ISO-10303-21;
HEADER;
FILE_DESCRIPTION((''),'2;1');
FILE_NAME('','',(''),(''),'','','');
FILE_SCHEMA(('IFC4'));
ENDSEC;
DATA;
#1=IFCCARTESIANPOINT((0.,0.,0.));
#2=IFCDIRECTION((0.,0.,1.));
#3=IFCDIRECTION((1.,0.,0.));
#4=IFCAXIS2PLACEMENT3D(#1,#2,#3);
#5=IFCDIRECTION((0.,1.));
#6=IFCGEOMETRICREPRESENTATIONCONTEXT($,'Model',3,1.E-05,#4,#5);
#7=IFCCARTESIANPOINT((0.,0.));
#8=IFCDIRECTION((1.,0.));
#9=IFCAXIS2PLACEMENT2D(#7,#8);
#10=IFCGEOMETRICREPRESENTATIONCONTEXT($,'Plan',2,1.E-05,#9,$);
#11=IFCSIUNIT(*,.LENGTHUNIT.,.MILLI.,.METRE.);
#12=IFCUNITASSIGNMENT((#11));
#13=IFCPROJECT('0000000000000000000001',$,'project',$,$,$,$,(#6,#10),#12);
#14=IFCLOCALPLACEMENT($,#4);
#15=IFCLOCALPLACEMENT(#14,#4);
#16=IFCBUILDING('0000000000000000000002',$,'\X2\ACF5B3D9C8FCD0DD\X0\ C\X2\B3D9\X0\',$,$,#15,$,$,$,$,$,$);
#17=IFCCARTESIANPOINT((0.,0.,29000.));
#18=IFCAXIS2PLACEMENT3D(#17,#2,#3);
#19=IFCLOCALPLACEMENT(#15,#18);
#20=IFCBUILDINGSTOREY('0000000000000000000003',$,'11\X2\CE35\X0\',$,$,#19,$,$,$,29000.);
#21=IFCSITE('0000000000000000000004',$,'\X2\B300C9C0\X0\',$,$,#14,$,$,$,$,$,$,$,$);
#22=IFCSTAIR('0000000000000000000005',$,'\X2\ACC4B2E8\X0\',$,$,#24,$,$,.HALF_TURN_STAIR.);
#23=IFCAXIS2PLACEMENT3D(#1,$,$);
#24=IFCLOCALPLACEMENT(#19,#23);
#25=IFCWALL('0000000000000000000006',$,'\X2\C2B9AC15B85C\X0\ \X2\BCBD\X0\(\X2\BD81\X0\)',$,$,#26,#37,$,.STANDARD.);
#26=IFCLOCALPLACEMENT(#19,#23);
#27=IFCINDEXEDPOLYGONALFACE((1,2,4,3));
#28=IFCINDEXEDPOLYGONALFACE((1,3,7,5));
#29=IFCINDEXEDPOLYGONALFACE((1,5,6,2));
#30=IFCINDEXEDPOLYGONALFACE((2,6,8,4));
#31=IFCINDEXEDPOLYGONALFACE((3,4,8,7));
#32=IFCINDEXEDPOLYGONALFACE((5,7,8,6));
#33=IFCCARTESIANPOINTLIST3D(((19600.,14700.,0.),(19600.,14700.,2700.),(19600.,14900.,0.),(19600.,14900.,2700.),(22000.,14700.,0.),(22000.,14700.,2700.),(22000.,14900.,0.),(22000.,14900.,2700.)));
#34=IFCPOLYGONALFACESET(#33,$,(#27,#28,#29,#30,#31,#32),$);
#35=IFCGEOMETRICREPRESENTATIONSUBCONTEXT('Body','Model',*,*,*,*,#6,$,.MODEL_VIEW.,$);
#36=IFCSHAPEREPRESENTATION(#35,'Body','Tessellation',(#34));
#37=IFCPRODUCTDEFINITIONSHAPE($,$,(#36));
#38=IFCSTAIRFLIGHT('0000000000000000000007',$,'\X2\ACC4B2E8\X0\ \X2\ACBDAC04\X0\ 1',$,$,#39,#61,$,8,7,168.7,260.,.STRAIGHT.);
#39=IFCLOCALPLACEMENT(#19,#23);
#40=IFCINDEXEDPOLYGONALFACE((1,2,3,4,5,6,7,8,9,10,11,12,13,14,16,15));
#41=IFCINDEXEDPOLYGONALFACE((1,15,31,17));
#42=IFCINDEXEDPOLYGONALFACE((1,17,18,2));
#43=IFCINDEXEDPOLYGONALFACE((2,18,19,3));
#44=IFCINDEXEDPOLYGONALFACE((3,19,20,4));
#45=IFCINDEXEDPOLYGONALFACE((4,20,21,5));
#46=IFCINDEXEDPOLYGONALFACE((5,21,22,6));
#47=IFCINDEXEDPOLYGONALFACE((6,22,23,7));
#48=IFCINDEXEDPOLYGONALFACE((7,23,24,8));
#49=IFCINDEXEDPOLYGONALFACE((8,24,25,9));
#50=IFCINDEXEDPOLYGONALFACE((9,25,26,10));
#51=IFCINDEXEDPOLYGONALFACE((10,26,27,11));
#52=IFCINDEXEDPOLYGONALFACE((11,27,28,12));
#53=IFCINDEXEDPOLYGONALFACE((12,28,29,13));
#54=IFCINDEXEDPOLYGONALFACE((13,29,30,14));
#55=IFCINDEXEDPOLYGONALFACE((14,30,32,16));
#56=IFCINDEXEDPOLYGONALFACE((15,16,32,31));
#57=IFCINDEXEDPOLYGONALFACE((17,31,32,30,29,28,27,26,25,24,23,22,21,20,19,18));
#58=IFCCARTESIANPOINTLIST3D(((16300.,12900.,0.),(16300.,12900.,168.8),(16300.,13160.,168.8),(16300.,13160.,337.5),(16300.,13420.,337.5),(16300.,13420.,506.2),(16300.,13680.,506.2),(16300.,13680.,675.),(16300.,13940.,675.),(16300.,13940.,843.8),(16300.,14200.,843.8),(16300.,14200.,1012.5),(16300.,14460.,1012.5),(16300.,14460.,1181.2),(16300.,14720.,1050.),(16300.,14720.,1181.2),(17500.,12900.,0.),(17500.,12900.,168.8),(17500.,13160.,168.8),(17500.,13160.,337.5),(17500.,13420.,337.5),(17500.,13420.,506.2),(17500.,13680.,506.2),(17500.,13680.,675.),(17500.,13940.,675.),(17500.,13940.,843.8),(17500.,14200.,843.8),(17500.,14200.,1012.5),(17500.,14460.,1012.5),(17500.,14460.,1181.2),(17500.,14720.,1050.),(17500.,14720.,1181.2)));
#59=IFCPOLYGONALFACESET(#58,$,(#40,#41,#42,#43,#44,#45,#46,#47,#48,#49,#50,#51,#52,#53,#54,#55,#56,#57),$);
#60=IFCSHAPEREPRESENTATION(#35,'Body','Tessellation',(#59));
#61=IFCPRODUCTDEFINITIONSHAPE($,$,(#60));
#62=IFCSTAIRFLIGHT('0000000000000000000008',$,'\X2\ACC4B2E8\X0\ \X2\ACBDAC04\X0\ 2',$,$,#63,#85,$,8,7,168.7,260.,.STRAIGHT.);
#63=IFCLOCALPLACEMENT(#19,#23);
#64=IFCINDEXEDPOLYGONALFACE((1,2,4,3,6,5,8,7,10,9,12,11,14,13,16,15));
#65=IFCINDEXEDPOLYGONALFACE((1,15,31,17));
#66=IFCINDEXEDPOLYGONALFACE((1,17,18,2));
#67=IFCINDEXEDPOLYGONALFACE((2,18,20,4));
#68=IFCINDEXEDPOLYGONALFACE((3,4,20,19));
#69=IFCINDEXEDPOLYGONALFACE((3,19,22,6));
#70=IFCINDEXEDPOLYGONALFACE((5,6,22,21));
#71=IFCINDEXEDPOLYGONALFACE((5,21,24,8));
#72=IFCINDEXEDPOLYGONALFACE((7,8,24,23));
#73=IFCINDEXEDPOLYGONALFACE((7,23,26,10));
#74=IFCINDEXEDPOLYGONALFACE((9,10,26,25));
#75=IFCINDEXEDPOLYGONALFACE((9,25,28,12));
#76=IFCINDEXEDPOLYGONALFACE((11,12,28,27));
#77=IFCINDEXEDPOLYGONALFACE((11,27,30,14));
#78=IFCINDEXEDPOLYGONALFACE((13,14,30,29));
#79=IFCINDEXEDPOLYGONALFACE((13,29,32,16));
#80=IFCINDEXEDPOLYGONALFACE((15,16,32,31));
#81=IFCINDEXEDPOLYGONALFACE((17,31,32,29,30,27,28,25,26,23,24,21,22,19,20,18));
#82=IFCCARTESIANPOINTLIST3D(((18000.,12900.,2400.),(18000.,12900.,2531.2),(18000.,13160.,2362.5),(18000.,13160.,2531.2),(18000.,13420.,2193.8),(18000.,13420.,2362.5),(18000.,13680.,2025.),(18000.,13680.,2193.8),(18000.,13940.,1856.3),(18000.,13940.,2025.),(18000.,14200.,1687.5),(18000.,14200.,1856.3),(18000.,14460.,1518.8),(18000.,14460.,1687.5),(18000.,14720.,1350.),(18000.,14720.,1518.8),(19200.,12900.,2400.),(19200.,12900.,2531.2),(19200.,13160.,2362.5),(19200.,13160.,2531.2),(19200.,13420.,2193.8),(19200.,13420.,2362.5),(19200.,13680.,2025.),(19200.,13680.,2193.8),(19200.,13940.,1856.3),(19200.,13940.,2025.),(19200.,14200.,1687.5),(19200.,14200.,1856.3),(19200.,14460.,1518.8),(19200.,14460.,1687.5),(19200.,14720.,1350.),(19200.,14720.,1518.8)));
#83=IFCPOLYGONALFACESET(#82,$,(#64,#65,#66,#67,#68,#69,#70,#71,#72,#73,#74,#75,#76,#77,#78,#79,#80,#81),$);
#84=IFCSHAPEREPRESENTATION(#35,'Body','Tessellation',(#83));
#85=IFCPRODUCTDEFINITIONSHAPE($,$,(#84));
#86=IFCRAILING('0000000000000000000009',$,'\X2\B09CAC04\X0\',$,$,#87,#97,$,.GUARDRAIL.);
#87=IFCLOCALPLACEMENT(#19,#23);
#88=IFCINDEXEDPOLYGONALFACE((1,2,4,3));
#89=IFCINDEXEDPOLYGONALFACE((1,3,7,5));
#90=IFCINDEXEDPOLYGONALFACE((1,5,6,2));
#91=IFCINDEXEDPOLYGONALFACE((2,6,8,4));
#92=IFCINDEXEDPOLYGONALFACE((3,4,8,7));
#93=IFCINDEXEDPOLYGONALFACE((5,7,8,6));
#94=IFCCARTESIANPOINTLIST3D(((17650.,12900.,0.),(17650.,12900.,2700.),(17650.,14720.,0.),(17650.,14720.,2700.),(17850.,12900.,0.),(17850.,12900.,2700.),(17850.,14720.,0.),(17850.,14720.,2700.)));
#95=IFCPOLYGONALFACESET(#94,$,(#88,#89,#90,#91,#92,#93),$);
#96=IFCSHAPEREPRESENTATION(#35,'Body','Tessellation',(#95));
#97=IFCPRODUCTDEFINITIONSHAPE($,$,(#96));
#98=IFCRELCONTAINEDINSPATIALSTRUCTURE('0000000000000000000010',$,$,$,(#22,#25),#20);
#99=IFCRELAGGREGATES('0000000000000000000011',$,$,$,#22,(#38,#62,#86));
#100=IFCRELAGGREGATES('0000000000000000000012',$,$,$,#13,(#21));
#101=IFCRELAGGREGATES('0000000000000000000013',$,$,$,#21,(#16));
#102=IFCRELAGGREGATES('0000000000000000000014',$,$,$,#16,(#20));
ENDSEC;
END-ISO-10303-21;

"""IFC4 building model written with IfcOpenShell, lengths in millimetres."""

from ifc_helpers import new_model, si_unit, direction, frame, origin_with_axes, origin_2d_with_axis, place, context, subcontext, project, spatial, polyline, outline, extrude, element, aggregate, save


model = new_model("IFC4")

# Units and contexts
model_context = context("Model", 3, precision=1e-05, world=origin_with_axes(), true_north=direction((0.0, 1.0)))
plan_context = context("Plan", 2, precision=1e-05, world=origin_2d_with_axis())
body_context = subcontext(model_context, "Body", "Model", "MODEL_VIEW")
ifc_project = project(units=[si_unit("LENGTHUNIT", "METRE", prefix="MILLI")], contexts=[model_context, plan_context])

# Site, building, storey
site_placement = place(None, origin_with_axes())
site = spatial("IfcSite", under=ifc_project, at=site_placement, Name="대지")
building_placement = place(site_placement, origin_with_axes())
building = spatial("IfcBuilding", under=site, at=building_placement, Name="공동주택 C동")
storey_placement = place(building_placement, frame((0.0, 0.0, 29000.0), z_axis=(0.0, 0.0, 1.0), x_axis=(1.0, 0.0, 0.0)))
storey = spatial("IfcBuildingStorey", under=building, at=storey_placement, Name="11층", Elevation=29000.0)

# Stair
stair_placement = place(storey_placement, origin_with_axes())
stair = element("IfcStair", 1, at=stair_placement, inside=storey, Name="계단", PredefinedType="HALF_TURN_STAIR")

# Wall
wall_1_placement = place(storey_placement, origin_with_axes())
element("IfcWall", 2, at=wall_1_placement, inside=storey, Name="승강로 벽(북)", PredefinedType="STANDARD", context=body_context, shape_type="SweptSolid", body=[
    extrude(outline(polyline([(19600.0, 14900.0), (22000.0, 14900.0), (22000.0, 14700.0), (19600.0, 14700.0), (19600.0, 14900.0)])), origin_with_axes(), (0.0, 0.0, 1.0), 2700.0),
])

# Stair flights
stair_flight_1_placement = place(stair_placement, origin_with_axes())
stair_flight_1 = element("IfcStairFlight", 3, at=stair_flight_1_placement, Name="계단 경간 1", NumberOfRisers=8, NumberOfTreads=7, PredefinedType="STRAIGHT", RiserHeight=168.7, TreadLength=260.0, context=body_context, shape_type="SweptSolid", body=[
    extrude(outline(polyline([(0.0, 0.0), (0.0, 168.7), (260.0, 168.7), (260.0, 337.5), (520.0, 337.5), (520.0, 506.2), (780.0, 506.2), (780.0, 675.0), (1040.0, 675.0), (1040.0, 843.7), (1300.0, 843.7), (1300.0, 1012.5), (1560.0, 1012.5), (1560.0, 1181.2), (1820.0, 1181.2), (1820.0, 1350.0), (1820.0, 1050.0), (0.0, 0.0)])), frame((16300.0, 12900.0, 0.0), z_axis=(1.0, 0.0, 0.0), x_axis=(0.0, 1.0, 0.0)), (0.0, 0.0, 1.0), 1200.0),
])
stair_flight_2_placement = place(stair_placement, origin_with_axes())
stair_flight_2 = element("IfcStairFlight", 4, at=stair_flight_2_placement, Name="계단 경간 2", NumberOfRisers=8, NumberOfTreads=7, PredefinedType="STRAIGHT", RiserHeight=168.7, TreadLength=260.0, context=body_context, shape_type="SweptSolid", body=[
    extrude(outline(polyline([(0.0, 0.0), (0.0, 168.7), (260.0, 168.7), (260.0, 337.5), (520.0, 337.5), (520.0, 506.2), (780.0, 506.2), (780.0, 675.0), (1040.0, 675.0), (1040.0, 843.7), (1300.0, 843.7), (1300.0, 1012.5), (1560.0, 1012.5), (1560.0, 1181.2), (1820.0, 1181.2), (1820.0, 1350.0), (1820.0, 1050.0), (0.0, 0.0)])), frame((19200.0, 14720.0, 1350.0), z_axis=(-1.0, 0.0, 0.0), x_axis=(0.0, -1.0, 0.0)), (0.0, 0.0, 1.0), 1200.0),
])

# Railing
railing_placement = place(stair_placement, origin_with_axes())
railing = element("IfcRailing", 5, at=railing_placement, Name="난간", PredefinedType="GUARDRAIL", context=body_context, shape_type="SweptSolid", body=[
    extrude(outline(polyline([(17650.0, 12900.0), (17850.0, 12900.0), (17850.0, 14720.0), (17650.0, 14720.0), (17650.0, 12900.0)])), origin_with_axes(), (0.0, 0.0, 1.0), 2700.0),
])
aggregate(stair, [stair_flight_1, stair_flight_2, railing])

save(model, "model.ifc")
